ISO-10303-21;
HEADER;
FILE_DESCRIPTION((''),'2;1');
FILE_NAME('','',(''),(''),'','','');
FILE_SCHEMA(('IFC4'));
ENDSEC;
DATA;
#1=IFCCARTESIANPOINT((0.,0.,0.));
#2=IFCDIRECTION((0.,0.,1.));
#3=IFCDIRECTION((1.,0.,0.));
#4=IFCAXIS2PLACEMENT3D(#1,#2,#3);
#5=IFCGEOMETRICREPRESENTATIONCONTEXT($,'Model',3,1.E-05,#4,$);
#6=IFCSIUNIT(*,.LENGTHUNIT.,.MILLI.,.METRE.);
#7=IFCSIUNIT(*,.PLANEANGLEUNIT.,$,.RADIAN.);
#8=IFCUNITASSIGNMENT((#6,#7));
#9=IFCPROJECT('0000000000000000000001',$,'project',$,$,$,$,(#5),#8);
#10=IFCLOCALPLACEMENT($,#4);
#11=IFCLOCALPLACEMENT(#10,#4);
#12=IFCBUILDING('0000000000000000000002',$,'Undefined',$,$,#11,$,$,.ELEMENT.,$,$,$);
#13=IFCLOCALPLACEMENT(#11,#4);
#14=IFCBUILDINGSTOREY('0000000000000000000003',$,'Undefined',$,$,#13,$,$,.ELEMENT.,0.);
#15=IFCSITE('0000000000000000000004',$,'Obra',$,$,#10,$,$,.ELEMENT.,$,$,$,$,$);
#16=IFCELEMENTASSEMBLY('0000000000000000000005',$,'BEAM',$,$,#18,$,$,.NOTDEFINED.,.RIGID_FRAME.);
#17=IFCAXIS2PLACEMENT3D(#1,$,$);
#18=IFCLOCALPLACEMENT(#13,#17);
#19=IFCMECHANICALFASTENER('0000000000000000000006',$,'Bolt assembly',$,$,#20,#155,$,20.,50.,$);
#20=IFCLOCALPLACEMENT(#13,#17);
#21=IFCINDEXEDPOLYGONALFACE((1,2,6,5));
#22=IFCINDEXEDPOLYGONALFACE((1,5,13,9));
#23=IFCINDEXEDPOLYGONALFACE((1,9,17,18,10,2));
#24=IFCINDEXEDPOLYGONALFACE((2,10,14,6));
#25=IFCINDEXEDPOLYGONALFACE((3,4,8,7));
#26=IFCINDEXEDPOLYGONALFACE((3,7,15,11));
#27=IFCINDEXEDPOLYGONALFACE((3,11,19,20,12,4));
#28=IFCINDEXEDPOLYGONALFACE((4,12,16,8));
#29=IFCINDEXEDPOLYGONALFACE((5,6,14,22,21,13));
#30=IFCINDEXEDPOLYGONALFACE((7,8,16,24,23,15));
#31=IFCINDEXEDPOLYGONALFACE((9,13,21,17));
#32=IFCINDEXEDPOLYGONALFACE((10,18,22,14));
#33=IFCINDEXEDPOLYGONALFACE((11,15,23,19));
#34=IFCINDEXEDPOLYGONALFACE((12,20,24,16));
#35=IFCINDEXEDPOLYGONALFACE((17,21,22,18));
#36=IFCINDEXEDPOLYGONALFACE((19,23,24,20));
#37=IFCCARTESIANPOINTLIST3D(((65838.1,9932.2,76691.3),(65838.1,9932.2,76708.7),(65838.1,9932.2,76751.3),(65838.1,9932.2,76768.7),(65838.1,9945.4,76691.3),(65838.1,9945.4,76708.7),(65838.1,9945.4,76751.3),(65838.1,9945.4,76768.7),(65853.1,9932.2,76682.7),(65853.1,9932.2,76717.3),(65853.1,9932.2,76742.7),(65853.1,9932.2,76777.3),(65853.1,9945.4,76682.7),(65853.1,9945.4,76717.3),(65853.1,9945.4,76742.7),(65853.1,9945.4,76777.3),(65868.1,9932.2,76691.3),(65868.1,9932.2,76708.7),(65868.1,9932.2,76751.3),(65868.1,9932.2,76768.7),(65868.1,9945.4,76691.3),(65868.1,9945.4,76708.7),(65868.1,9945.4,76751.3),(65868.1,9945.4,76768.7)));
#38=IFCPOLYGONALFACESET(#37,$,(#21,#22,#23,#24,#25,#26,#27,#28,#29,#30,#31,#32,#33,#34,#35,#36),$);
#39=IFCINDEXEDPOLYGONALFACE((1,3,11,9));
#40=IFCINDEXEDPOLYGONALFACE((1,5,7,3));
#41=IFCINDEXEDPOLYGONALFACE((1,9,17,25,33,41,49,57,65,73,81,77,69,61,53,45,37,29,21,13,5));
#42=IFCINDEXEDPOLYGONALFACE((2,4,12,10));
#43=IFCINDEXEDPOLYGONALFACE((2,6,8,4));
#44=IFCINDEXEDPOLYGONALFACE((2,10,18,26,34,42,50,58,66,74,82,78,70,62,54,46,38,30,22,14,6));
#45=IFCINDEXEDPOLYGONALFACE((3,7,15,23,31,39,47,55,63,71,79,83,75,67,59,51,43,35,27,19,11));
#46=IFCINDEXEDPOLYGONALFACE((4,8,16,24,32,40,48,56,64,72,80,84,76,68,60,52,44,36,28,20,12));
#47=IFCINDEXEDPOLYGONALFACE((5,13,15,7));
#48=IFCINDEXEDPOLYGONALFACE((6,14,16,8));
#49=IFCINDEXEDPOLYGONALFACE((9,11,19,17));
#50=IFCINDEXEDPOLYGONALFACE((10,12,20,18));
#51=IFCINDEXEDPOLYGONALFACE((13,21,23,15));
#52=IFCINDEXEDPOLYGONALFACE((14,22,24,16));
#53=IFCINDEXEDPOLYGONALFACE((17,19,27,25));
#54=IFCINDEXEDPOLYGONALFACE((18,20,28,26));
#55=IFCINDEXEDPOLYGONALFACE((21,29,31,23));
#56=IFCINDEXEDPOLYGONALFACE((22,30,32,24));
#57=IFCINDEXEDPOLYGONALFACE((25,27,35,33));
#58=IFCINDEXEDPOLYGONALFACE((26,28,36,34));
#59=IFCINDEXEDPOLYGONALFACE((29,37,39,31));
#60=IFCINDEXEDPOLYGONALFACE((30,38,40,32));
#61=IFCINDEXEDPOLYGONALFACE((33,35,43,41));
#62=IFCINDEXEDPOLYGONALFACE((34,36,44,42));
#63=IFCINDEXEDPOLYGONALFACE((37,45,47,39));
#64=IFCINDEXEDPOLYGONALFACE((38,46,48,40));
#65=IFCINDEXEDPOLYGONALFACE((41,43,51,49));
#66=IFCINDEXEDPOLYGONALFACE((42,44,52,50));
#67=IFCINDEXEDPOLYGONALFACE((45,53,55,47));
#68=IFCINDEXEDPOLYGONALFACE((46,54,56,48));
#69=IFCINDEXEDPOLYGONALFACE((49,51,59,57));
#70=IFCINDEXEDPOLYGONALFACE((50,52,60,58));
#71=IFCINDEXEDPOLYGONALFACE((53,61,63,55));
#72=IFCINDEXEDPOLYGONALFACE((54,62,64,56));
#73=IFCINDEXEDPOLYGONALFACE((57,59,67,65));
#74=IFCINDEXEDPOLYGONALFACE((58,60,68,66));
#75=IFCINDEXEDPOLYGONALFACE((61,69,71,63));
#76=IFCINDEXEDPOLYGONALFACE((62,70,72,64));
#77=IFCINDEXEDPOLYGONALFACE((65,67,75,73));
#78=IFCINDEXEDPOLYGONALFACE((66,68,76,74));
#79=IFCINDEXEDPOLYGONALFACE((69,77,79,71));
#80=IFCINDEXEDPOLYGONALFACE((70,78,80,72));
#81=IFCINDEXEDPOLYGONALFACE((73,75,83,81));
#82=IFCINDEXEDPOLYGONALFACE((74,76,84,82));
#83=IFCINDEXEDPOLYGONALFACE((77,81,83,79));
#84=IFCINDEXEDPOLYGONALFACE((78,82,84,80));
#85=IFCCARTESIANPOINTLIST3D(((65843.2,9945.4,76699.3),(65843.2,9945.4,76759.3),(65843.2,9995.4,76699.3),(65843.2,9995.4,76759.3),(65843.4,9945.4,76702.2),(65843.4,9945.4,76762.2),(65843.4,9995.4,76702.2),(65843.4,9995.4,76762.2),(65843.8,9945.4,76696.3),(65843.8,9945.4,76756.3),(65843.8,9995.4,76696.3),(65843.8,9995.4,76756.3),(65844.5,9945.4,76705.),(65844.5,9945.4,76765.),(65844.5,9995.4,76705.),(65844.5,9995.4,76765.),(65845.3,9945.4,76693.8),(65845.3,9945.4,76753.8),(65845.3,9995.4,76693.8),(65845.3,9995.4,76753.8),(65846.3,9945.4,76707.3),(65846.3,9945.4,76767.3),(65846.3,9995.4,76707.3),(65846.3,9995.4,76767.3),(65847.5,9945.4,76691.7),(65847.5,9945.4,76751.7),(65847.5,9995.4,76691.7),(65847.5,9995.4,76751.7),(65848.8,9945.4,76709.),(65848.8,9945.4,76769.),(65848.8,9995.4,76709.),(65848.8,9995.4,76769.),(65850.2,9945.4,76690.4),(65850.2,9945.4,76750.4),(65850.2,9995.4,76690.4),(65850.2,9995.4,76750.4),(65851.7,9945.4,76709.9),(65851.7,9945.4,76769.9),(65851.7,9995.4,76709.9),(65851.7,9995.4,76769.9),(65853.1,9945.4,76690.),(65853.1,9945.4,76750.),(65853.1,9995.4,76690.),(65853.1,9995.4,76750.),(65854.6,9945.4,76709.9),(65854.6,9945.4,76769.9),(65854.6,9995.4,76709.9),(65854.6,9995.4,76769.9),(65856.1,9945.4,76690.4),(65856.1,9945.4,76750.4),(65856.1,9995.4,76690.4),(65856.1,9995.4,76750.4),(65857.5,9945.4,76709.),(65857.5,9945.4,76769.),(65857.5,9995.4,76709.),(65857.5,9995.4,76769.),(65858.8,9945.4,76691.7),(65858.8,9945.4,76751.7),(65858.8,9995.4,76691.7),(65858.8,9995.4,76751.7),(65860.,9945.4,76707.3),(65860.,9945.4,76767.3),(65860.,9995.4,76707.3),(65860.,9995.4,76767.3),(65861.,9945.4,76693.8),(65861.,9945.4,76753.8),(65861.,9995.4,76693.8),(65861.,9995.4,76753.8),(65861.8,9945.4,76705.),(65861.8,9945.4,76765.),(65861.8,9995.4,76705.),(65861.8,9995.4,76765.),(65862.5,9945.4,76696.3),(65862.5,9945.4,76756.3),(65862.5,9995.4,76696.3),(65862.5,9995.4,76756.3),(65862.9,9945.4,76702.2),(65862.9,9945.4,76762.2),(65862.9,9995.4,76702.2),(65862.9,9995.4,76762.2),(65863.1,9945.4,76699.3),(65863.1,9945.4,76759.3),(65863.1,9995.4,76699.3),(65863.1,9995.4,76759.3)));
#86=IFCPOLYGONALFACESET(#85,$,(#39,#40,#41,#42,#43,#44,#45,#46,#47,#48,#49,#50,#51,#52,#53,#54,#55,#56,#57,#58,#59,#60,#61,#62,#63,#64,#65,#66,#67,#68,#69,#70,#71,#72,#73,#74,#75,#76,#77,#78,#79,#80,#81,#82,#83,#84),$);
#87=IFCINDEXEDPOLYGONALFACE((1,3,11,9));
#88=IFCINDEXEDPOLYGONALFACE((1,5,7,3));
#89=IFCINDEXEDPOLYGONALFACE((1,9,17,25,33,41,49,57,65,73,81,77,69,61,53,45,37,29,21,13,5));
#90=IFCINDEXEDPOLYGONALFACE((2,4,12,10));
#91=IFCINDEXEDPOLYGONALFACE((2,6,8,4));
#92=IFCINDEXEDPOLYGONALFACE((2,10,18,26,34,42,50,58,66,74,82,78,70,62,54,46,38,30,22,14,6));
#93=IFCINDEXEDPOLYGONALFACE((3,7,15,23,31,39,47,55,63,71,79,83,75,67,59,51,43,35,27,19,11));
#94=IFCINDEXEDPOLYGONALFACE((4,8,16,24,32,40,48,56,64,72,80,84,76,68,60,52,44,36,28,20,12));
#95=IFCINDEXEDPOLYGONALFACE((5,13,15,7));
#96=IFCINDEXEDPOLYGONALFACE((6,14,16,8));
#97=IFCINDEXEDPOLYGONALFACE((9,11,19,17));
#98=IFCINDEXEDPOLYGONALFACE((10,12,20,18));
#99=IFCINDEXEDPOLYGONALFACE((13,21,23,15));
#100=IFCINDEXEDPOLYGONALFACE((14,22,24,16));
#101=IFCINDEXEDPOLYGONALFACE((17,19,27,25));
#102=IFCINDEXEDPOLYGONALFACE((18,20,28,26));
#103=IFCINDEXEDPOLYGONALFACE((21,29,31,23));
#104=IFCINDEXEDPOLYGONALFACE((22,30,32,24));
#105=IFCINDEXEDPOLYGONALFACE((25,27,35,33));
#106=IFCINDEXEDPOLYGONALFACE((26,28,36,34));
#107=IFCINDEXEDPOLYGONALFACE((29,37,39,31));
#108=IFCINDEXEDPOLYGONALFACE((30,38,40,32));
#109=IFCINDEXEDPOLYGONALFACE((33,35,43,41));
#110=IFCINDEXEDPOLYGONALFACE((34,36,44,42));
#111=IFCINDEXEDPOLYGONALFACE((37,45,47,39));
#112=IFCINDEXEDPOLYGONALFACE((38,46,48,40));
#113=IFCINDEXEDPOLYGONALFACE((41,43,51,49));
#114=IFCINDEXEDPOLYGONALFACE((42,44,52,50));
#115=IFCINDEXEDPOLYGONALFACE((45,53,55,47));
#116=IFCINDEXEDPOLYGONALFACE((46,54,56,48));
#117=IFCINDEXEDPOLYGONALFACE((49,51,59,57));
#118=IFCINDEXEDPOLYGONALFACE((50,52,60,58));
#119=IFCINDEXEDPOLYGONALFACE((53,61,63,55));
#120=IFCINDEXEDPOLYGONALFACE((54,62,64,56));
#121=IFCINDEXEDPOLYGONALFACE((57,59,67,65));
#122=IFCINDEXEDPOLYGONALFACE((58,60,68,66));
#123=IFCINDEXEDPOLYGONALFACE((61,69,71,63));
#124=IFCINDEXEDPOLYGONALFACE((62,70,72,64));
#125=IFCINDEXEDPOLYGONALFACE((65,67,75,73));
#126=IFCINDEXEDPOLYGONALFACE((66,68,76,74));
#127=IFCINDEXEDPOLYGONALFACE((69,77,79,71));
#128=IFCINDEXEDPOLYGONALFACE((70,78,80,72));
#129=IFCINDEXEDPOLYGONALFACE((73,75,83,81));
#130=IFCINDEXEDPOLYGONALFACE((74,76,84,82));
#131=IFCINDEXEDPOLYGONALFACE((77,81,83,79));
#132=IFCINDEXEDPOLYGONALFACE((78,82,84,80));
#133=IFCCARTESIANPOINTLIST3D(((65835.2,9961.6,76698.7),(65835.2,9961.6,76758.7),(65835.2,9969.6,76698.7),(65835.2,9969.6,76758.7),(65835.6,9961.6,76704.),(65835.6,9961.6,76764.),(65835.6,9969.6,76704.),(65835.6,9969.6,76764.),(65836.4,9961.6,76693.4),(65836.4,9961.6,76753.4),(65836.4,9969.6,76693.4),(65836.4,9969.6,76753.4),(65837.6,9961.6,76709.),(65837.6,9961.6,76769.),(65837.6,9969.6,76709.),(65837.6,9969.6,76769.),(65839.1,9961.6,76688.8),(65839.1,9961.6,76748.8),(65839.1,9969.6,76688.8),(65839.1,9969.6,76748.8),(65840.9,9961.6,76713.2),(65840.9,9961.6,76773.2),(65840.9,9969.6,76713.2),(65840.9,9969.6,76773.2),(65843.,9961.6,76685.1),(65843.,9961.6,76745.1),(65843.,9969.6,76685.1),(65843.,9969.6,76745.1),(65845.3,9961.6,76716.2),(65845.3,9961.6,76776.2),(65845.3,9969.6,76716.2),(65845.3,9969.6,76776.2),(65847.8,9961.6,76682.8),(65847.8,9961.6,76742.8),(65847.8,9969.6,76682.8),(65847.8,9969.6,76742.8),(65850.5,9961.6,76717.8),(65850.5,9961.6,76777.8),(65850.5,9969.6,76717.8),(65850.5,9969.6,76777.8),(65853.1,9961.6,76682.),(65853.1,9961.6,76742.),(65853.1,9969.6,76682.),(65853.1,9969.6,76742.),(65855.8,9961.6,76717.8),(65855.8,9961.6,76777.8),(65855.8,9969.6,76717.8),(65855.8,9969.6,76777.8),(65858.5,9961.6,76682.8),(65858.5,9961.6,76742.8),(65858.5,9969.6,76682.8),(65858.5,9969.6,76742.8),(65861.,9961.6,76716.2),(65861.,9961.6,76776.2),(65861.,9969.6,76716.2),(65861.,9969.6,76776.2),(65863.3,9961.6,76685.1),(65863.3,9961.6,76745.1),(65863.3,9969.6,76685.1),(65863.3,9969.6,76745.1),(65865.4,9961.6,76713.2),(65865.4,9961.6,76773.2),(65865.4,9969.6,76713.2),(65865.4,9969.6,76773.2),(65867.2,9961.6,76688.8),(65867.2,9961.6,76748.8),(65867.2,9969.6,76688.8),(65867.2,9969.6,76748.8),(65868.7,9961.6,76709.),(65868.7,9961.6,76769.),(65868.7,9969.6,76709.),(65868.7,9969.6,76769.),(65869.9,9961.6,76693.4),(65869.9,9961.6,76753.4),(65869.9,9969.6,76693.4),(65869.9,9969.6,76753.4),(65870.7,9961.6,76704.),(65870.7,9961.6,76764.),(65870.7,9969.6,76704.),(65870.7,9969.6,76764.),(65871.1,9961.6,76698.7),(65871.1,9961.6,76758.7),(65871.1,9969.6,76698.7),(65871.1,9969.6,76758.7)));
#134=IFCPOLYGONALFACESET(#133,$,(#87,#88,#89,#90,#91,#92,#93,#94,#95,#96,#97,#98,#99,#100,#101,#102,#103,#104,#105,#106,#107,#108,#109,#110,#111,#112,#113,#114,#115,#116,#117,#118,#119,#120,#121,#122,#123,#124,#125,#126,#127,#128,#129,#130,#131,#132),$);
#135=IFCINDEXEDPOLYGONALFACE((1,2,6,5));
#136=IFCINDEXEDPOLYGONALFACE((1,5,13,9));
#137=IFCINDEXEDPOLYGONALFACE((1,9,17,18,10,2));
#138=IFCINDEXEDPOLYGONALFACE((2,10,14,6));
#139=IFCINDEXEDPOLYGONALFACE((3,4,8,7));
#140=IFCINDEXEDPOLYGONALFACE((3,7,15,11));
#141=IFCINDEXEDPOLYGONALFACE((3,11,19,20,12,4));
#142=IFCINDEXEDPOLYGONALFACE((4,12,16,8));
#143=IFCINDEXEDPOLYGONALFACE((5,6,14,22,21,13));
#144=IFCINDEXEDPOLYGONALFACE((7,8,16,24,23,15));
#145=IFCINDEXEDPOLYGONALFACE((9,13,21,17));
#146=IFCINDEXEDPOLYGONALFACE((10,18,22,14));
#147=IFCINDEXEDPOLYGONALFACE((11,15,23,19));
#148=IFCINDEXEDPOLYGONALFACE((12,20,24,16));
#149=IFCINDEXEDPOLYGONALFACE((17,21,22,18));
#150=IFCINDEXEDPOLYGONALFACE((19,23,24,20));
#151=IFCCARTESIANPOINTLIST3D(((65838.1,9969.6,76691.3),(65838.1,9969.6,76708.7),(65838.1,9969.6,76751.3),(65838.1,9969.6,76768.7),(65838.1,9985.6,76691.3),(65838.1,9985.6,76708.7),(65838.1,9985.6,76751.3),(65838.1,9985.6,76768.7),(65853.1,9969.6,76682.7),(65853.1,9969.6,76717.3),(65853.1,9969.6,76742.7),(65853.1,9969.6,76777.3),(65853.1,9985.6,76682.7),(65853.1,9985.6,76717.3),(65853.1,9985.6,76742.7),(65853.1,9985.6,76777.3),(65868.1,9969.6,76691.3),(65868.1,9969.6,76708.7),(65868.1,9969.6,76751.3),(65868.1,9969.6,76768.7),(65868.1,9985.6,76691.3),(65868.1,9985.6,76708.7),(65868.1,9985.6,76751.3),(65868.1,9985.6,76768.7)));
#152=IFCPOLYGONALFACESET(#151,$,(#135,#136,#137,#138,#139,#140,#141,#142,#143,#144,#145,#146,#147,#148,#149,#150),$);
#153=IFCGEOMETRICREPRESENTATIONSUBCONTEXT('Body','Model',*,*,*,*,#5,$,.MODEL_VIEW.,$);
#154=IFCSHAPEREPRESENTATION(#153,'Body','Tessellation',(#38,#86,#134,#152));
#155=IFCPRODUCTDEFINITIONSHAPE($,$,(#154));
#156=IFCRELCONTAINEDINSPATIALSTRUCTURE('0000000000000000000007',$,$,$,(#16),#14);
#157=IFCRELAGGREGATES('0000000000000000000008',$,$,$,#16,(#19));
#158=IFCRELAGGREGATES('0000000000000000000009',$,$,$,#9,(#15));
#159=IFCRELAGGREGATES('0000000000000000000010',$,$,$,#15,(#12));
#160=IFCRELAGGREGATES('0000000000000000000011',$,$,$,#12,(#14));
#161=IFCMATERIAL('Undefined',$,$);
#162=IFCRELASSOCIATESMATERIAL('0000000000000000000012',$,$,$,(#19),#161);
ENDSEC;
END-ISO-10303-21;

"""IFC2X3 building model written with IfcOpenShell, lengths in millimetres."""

from ifc_helpers import new_model, si_unit, frame, origin_with_axes, origin_2d_with_axis, place, context, subcontext, project, spatial, polyline, circle, outline, extrude, source, transform, mapped, material, element, aggregate, save


model = new_model("IFC2X3")

# Units and contexts
model_context = context("Model", 3, precision=1e-05, world=origin_with_axes())
body_context = subcontext(model_context, "Body", "Model", "MODEL_VIEW")
ifc_project = project(units=[si_unit("LENGTHUNIT", "METRE", prefix="MILLI"), si_unit("PLANEANGLEUNIT", "RADIAN")], contexts=[model_context])

# Site, building, storey
site_placement = place(None, origin_with_axes())
site = spatial("IfcSite", under=ifc_project, at=site_placement, Name="Obra", CompositionType="ELEMENT")
building_placement = place(site_placement, origin_with_axes())
building = spatial("IfcBuilding", under=site, at=building_placement, Name="Undefined", CompositionType="ELEMENT")
storey_placement = place(building_placement, origin_with_axes())
storey = spatial("IfcBuildingStorey", under=building, at=storey_placement, Name="Undefined", CompositionType="ELEMENT", Elevation=0.0)

# Element assembly
assembly_1_placement = place(storey_placement, origin_with_axes())
assembly_1 = element("IfcElementAssembly", 1, at=assembly_1_placement, inside=storey, Name="BEAM", AssemblyPlace="NOTDEFINED", PredefinedType="RIGID_FRAME")

# Mechanical fastener
ifc_material_1 = material(Name="Undefined")
shared_shape_1 = source(origin_with_axes(), body_context, "Body", "SweptSolid", [
    extrude(outline(polyline([(17.3, 0.0), (8.7, 15.0), (-8.7, 15.0), (-17.3, 0.0), (-8.7, -15.0), (8.7, -15.0), (17.3, 0.0)])), frame((0.0, -26.3, 0.0), z_axis=(0.0, 1.0, 0.0), x_axis=(1.0, 0.0, 0.0)), (0.0, 0.0, 1.0), 13.2),
    extrude(circle(Radius=10.0, at=origin_2d_with_axis()), frame((0.0, -13.1, 0.0), z_axis=(0.0, 1.0, 0.0), x_axis=(1.0, 0.0, 0.0)), (0.0, 0.0, 1.0), 50.0),
    extrude(circle(Radius=18.0, at=origin_2d_with_axis()), frame((0.0, 3.1, 0.0), z_axis=(0.0, 1.0, 0.0), x_axis=(1.0, 0.0, 0.0)), (0.0, 0.0, 1.0), 8.0),
    extrude(outline(polyline([(17.3, 0.0), (8.7, 15.0), (-8.7, 15.0), (-17.3, 0.0), (-8.7, -15.0), (8.7, -15.0), (17.3, 0.0)])), frame((0.0, 11.1, 0.0), z_axis=(0.0, 1.0, 0.0), x_axis=(1.0, 0.0, 0.0)), (0.0, 0.0, 1.0), 16.0),
])
mechanical_fastener_1_placement = place(assembly_1_placement, frame((65813.1, 9958.5, 76850.0), z_axis=(1.0, 0.0, 0.0), x_axis=(0.0, 0.0, -1.0)))
mechanical_fastener_1 = element("IfcMechanicalFastener", 2, at=mechanical_fastener_1_placement, material=ifc_material_1, Name="Bolt assembly", NominalDiameter=20.0, NominalLength=50.0, context=body_context, shape_type="MappedRepresentation", body=[
    mapped(shared_shape_1, transform((90.0, 0.0, 40.0))),
    mapped(shared_shape_1, transform((150.0, 0.0, 40.0))),
])

aggregate(assembly_1, [mechanical_fastener_1])

save(model, "model.ifc")
